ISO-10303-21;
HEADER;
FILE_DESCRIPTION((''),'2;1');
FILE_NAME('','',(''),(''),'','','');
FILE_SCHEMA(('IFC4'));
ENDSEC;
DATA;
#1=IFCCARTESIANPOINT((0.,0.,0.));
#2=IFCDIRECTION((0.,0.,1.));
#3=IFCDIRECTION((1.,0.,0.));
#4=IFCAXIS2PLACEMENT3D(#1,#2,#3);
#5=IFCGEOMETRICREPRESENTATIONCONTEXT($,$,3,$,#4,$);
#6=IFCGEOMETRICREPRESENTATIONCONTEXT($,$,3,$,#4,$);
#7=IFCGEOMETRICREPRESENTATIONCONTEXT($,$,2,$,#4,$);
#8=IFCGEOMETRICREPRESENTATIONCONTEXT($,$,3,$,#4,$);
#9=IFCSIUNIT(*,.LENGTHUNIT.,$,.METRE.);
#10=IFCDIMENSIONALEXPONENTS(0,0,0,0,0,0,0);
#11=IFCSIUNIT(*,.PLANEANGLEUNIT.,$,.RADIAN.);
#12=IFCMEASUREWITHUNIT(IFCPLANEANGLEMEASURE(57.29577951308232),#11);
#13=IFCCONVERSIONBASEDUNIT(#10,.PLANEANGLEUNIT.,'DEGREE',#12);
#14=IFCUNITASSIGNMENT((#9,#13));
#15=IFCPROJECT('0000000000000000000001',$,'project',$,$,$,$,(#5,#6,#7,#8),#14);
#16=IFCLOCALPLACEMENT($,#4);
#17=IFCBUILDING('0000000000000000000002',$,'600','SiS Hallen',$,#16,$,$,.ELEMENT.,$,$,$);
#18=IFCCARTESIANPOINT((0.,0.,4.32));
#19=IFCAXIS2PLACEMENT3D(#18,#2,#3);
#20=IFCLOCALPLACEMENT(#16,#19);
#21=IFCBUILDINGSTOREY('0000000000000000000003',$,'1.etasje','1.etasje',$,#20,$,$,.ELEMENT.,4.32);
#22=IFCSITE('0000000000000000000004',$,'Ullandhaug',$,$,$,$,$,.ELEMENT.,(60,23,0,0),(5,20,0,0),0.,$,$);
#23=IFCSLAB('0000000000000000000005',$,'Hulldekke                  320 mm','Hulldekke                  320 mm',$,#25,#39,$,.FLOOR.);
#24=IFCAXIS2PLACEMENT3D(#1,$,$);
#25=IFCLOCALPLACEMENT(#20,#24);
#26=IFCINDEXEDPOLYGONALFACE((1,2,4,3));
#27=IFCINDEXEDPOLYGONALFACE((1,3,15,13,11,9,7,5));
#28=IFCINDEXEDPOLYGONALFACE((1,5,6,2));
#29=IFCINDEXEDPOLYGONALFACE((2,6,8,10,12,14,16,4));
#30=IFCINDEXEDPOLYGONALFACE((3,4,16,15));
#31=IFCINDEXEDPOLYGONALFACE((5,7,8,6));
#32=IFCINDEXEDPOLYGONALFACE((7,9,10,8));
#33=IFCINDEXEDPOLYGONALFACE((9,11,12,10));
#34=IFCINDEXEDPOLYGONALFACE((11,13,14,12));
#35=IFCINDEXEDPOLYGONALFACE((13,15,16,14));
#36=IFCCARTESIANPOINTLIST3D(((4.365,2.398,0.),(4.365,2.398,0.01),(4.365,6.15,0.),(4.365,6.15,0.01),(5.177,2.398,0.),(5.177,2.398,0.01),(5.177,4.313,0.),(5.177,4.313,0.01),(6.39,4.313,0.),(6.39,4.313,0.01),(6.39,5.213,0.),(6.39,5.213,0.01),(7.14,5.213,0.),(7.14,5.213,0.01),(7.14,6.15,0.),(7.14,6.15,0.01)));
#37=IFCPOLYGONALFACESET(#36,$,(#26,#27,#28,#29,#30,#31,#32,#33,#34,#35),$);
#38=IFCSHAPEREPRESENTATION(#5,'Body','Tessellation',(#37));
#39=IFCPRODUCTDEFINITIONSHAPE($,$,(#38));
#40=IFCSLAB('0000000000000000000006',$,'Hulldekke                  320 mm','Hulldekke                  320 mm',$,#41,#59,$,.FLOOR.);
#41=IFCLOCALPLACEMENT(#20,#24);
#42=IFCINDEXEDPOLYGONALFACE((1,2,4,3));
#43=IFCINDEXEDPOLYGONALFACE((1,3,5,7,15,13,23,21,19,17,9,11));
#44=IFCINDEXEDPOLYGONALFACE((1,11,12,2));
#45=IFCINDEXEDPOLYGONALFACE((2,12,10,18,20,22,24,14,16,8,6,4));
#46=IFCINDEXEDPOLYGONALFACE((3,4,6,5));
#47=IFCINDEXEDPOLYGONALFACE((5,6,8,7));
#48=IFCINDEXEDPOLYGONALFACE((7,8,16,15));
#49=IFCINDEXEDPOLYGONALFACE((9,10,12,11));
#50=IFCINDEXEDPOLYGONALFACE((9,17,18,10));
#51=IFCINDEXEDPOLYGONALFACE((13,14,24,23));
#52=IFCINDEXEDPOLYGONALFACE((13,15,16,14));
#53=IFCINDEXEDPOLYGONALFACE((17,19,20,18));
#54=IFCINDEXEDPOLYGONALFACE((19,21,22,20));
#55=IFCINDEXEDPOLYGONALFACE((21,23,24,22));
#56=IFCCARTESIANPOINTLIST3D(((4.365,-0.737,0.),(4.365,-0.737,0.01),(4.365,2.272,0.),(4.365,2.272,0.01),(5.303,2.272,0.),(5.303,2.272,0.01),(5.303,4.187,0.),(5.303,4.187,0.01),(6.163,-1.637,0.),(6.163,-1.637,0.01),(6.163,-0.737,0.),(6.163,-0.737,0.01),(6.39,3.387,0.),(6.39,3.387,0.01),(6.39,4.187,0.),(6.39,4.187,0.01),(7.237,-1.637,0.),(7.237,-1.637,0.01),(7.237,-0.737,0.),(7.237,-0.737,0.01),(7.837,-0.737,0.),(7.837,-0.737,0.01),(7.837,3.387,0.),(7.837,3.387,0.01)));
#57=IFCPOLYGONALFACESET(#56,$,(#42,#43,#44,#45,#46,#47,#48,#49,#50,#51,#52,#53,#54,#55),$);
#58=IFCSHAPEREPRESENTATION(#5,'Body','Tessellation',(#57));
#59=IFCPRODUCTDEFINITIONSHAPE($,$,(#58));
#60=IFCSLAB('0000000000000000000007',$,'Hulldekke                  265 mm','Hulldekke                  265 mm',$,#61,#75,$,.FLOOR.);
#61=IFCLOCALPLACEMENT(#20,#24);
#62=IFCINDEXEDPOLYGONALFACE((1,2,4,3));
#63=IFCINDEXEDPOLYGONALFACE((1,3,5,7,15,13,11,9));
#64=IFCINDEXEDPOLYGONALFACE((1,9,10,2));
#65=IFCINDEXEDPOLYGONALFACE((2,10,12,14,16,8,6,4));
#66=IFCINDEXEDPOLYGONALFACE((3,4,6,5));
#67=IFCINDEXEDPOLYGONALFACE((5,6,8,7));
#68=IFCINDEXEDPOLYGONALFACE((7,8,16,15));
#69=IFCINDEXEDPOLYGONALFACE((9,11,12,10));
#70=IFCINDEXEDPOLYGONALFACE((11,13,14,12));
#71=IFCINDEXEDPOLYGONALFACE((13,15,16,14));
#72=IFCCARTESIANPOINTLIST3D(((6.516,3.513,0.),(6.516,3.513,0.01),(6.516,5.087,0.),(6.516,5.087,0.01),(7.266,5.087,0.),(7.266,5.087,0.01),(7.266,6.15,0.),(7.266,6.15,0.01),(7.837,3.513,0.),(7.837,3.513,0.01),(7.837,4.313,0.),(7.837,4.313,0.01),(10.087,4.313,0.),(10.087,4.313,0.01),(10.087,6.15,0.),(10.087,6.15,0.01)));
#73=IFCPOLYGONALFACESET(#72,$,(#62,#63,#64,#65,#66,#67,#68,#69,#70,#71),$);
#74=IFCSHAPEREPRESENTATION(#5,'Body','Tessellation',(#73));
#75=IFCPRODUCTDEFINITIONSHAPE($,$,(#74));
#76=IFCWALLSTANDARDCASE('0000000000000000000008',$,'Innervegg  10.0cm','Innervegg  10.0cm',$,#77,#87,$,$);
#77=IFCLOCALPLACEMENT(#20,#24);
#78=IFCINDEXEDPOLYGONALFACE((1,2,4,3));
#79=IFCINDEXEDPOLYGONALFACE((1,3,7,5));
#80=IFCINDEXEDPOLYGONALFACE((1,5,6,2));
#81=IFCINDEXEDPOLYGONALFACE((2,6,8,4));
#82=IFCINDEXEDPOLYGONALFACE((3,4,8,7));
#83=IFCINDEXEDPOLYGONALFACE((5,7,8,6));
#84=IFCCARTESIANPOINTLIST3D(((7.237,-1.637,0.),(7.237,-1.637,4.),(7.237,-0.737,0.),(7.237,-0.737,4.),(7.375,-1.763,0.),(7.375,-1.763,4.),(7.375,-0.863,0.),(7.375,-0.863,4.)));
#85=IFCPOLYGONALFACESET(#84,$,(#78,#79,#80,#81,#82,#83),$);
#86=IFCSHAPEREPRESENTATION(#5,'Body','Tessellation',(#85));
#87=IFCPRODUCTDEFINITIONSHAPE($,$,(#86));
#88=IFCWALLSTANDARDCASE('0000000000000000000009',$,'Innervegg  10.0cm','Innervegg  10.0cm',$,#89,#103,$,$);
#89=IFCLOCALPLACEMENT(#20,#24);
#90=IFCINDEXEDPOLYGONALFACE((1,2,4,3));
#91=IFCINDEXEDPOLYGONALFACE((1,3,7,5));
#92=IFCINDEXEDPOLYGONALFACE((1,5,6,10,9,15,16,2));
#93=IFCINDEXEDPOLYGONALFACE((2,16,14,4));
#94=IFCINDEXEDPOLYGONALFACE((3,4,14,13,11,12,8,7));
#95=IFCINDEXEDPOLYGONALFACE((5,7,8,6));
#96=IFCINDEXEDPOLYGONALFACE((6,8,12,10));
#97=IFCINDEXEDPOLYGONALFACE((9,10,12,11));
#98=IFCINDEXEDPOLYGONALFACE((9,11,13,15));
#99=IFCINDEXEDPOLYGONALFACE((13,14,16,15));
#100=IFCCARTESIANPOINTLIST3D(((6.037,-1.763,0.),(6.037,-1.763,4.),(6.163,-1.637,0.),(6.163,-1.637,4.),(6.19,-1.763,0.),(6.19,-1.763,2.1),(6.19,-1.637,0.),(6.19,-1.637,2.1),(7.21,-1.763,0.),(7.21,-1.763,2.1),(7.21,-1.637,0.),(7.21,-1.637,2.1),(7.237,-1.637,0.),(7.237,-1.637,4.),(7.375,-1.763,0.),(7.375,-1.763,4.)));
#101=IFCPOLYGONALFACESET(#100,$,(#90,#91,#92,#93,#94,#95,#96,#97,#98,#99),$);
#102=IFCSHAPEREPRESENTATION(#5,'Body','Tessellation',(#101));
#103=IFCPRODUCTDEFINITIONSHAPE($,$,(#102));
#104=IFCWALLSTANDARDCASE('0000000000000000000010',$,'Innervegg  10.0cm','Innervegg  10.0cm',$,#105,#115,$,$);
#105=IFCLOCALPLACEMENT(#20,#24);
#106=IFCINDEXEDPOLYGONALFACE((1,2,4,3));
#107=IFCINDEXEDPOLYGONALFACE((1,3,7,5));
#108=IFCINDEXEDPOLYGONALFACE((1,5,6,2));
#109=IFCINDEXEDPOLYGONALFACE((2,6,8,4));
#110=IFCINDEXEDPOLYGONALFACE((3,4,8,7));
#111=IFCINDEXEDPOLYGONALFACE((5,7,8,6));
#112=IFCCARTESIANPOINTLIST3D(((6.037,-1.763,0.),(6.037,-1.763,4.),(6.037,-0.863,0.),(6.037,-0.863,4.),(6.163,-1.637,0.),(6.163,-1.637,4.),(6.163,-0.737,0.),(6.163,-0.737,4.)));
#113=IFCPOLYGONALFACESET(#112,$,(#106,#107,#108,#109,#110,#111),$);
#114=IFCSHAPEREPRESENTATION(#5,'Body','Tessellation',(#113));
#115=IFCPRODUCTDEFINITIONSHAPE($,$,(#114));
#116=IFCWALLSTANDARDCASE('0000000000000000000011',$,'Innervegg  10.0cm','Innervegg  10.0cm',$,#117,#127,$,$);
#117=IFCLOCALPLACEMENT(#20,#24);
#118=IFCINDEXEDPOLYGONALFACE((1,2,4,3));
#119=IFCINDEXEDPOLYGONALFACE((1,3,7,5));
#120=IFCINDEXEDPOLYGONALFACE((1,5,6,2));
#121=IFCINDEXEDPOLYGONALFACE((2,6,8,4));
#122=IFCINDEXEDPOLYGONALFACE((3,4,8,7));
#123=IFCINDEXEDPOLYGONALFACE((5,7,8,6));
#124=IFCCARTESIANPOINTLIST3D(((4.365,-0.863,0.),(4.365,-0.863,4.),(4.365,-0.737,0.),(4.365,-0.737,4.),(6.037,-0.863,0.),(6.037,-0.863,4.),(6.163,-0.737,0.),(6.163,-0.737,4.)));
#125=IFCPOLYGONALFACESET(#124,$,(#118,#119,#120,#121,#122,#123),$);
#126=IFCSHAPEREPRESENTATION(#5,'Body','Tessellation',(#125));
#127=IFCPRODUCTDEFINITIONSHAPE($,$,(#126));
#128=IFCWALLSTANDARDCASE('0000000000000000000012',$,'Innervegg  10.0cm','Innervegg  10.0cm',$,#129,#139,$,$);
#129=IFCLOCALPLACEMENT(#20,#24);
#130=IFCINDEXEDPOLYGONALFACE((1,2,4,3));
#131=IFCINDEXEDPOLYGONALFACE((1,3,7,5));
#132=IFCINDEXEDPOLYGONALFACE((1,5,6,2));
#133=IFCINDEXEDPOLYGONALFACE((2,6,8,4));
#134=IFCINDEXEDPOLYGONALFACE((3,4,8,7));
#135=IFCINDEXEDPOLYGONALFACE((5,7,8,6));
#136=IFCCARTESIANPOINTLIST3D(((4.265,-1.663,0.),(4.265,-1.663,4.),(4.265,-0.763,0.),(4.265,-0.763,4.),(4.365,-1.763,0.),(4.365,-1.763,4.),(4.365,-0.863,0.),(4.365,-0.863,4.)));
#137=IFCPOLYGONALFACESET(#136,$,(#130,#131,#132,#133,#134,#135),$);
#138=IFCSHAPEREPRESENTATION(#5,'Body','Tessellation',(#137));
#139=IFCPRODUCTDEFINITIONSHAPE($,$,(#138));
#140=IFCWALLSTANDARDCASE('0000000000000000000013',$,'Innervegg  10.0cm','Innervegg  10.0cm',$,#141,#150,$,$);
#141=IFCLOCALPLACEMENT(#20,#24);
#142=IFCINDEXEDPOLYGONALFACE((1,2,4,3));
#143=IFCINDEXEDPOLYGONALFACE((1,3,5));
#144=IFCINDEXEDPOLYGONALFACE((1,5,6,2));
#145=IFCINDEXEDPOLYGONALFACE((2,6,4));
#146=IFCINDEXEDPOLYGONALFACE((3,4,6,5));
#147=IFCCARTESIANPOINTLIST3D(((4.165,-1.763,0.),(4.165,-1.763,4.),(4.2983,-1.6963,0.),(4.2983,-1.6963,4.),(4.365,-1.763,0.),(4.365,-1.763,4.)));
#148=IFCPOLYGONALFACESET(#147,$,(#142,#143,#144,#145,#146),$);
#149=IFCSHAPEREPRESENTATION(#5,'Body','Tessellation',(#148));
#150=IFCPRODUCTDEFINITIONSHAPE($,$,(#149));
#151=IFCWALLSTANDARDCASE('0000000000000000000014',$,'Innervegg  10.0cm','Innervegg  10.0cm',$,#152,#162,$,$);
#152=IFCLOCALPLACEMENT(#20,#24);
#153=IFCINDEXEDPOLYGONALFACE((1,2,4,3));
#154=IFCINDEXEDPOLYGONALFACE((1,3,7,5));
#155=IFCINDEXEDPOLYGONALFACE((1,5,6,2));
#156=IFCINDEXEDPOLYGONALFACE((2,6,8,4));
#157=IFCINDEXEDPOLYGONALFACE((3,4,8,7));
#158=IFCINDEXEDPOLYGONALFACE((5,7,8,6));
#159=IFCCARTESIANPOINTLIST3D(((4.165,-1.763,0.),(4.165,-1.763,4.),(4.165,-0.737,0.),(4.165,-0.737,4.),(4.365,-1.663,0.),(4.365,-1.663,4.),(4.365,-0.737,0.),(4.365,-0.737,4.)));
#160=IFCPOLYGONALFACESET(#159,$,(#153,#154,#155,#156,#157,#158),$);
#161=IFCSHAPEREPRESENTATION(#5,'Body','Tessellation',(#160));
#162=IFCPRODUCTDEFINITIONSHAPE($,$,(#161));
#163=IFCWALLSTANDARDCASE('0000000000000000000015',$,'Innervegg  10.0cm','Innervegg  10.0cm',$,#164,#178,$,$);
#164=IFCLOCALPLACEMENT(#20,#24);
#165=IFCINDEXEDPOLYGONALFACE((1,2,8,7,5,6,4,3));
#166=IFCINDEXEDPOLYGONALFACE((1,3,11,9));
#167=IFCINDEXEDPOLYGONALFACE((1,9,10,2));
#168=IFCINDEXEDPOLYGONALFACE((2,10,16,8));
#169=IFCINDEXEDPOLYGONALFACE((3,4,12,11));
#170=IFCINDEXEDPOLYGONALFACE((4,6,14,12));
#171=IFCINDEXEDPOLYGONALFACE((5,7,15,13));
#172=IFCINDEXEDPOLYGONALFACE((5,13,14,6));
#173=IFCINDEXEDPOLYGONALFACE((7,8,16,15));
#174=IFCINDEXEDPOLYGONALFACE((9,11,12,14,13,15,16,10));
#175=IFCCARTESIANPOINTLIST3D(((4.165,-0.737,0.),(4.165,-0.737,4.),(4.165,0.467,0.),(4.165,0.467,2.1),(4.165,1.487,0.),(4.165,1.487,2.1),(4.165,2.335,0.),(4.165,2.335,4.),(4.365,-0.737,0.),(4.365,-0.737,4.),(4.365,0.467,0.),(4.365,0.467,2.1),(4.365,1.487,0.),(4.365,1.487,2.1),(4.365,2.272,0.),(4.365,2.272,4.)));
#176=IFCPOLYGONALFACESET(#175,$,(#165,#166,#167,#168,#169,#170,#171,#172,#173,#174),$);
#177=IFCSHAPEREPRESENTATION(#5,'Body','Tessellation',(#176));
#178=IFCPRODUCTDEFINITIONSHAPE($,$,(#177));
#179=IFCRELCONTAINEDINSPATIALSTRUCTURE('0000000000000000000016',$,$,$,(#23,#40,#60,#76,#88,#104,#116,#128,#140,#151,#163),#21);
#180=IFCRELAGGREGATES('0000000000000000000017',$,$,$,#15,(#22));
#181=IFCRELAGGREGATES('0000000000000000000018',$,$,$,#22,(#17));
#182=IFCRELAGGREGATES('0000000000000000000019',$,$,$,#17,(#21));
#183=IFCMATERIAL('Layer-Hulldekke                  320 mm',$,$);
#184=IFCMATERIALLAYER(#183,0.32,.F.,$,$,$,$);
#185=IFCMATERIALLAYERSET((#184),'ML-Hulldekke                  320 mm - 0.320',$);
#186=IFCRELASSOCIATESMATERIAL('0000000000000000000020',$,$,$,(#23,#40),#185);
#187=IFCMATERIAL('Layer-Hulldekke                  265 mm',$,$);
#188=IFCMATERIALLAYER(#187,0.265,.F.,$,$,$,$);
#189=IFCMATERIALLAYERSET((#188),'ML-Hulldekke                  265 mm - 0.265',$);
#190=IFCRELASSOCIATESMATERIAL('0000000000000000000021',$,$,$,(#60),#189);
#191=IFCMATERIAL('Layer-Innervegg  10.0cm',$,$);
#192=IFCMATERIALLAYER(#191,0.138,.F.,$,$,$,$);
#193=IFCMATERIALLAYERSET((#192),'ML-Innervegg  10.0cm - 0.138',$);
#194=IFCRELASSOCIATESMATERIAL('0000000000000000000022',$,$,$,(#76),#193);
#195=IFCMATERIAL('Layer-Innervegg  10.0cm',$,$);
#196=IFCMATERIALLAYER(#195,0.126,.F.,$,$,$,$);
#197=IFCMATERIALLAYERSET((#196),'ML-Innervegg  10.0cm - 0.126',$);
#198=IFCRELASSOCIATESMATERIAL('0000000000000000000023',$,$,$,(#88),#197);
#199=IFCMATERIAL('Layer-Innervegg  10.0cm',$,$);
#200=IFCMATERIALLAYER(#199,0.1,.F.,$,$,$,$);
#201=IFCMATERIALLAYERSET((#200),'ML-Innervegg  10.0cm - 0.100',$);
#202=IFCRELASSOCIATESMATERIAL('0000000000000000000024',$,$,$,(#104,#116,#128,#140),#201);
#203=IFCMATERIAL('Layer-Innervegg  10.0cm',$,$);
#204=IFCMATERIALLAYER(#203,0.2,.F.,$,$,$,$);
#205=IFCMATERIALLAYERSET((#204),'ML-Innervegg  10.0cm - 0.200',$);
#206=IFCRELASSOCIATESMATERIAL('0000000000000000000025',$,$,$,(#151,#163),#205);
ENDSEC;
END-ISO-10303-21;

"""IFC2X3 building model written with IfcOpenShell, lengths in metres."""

from ifc_helpers import new_model, entity, si_unit, converted_unit, frame, origin_with_axes, place, context, project, spatial, polyline, outline, extrude, material, layer, layer_set, layer_usage, element, save


model = new_model("IFC2X3")

# Units and contexts
context_of_model_1 = context(None, 3, world=origin_with_axes())
context_of_model_2 = context(None, 3, world=origin_with_axes())
context_of_model_3 = context(None, 2, world=origin_with_axes())
context_of_model_4 = context(None, 3, world=origin_with_axes())
ifc_project = project(units=[si_unit("LENGTHUNIT", "METRE"), converted_unit("PLANEANGLEUNIT", "DEGREE", entity("IfcPlaneAngleMeasure", 57.29577951308232), si_unit("PLANEANGLEUNIT", "RADIAN"), dimensions=[0, 0, 0, 0, 0, 0, 0])], contexts=[context_of_model_1, context_of_model_2, context_of_model_3, context_of_model_4])

# Site, building, storey
site = spatial("IfcSite", under=ifc_project, Name="Ullandhaug", CompositionType="ELEMENT", RefLatitude=(60, 23, 0, 0), RefLongitude=(5, 20, 0, 0), RefElevation=0.0)
building_placement = place(None, origin_with_axes())
building = spatial("IfcBuilding", under=site, at=building_placement, Name="600", Description="SiS Hallen", CompositionType="ELEMENT")
storey_placement = place(building_placement, frame((0.0, 0.0, 4.32), z_axis=(0.0, 0.0, 1.0), x_axis=(1.0, 0.0, 0.0)))
storey = spatial("IfcBuildingStorey", under=building, at=storey_placement, Name="1.etasje", Description="1.etasje", CompositionType="ELEMENT", Elevation=4.32)

# Slabs
ifc_material_1 = material(Name="Layer-Hulldekke                  320 mm")
ifc_layer_1 = layer(ifc_material_1, 0.32, ventilated=False)
ifc_layer_set_1 = layer_set([ifc_layer_1], Name="ML-Hulldekke                  320 mm - 0.320")
ifc_layer_usage_1 = layer_usage(ifc_layer_set_1, "AXIS2", "POSITIVE", 0.0)
slab_1_placement = place(storey_placement, frame((4.365, 2.398, 0.0), z_axis=(0.0, 0.0, 1.0), x_axis=(1.0, 0.0, 0.0)))
element("IfcSlab", 1, at=slab_1_placement, inside=storey, material=ifc_layer_usage_1, Name="Hulldekke                  320 mm", Description="Hulldekke                  320 mm", PredefinedType="FLOOR", context=context_of_model_1, shape_type="SweptSolid", body=[
    extrude(outline(polyline([(0.0, 0.0), (0.812, 0.0), (0.812, 1.915), (2.025, 1.915), (2.025, 2.815), (2.775, 2.815), (2.775, 3.752), (0.0, 3.752), (0.0, 0.0)])), origin_with_axes(), (0.0, 0.0, 1.0), 0.01),
])
slab_2_placement = place(storey_placement, frame((6.163, -1.637, 0.0), z_axis=(0.0, 0.0, 1.0), x_axis=(1.0, 0.0, 0.0)))
element("IfcSlab", 2, at=slab_2_placement, inside=storey, material=ifc_layer_usage_1, Name="Hulldekke                  320 mm", Description="Hulldekke                  320 mm", PredefinedType="FLOOR", context=context_of_model_1, shape_type="SweptSolid", body=[
    extrude(outline(polyline([(0.0, 0.0), (1.074, 0.0), (1.074, 0.9), (1.674, 0.9), (1.674, 5.024), (0.227, 5.024), (0.227, 5.824), (-0.86, 5.824), (-0.86, 3.909), (-1.798, 3.909), (-1.798, 0.9), (0.0, 0.9), (0.0, 0.0)])), origin_with_axes(), (0.0, 0.0, 1.0), 0.01),
])
ifc_material_2 = material(Name="Layer-Hulldekke                  265 mm")
ifc_layer_2 = layer(ifc_material_2, 0.265, ventilated=False)
ifc_layer_set_2 = layer_set([ifc_layer_2], Name="ML-Hulldekke                  265 mm - 0.265")
ifc_layer_usage_2 = layer_usage(ifc_layer_set_2, "AXIS2", "POSITIVE", 0.0)
slab_3_placement = place(storey_placement, frame((6.516, 3.513, 0.0), z_axis=(0.0, 0.0, 1.0), x_axis=(1.0, 0.0, 0.0)))
element("IfcSlab", 3, at=slab_3_placement, inside=storey, material=ifc_layer_usage_2, Name="Hulldekke                  265 mm", Description="Hulldekke                  265 mm", PredefinedType="FLOOR", context=context_of_model_1, shape_type="SweptSolid", body=[
    extrude(outline(polyline([(0.0, 0.0), (1.321, 0.0), (1.321, 0.8), (3.571, 0.8), (3.571, 2.637), (0.75, 2.637), (0.75, 1.574), (0.0, 1.574), (0.0, 0.0)])), origin_with_axes(), (0.0, 0.0, 1.0), 0.01),
])

# Wall
ifc_material_3 = material(Name="Layer-Innervegg  10.0cm")
ifc_layer_3 = layer(ifc_material_3, 0.138, ventilated=False)
ifc_layer_set_3 = layer_set([ifc_layer_3], Name="ML-Innervegg  10.0cm - 0.138")
ifc_layer_usage_3 = layer_usage(ifc_layer_set_3, "AXIS2", "POSITIVE", 0.0)
wall_1_placement = place(storey_placement, frame((7.237, -0.737, 0.0), z_axis=(0.0, 0.0, 1.0), x_axis=(0.0, -1.0, 0.0)))
element("IfcWallStandardCase", 4, at=wall_1_placement, inside=storey, material=ifc_layer_usage_3, Name="Innervegg  10.0cm", Description="Innervegg  10.0cm", context=context_of_model_1, shape_type="SweptSolid", body=[
    extrude(outline(polyline([(0.0, 0.0), (0.9, 0.0), (1.026, 0.138), (0.126, 0.138), (0.0, 0.0)])), frame((0.0, 0.0, 0.0), z_axis=(0.0, 0.0, 1.0), x_axis=(1.0, 0.0, 0.0)), (0.0, 0.0, 1.0), 4.0),
])

# Wall, opening
ifc_material_4 = material(Name="Layer-Innervegg  10.0cm")
ifc_layer_4 = layer(ifc_material_4, 0.126, ventilated=False)
ifc_layer_set_4 = layer_set([ifc_layer_4], Name="ML-Innervegg  10.0cm - 0.126")
ifc_layer_usage_4 = layer_usage(ifc_layer_set_4, "AXIS2", "POSITIVE", 0.0)
wall_2_placement = place(storey_placement, frame((7.237, -1.637, 0.0), z_axis=(0.0, 0.0, 1.0), x_axis=(-1.0, 0.0, 0.0)))
wall_2 = element("IfcWallStandardCase", 5, at=wall_2_placement, inside=storey, material=ifc_layer_usage_4, Name="Innervegg  10.0cm", Description="Innervegg  10.0cm", context=context_of_model_1, shape_type="SweptSolid", body=[
    extrude(outline(polyline([(0.0, 0.0), (1.074, 0.0), (1.2, 0.126), (-0.138, 0.126), (0.0, 0.0)])), frame((0.0, 0.0, 0.0), z_axis=(0.0, 0.0, 1.0), x_axis=(1.0, 0.0, 0.0)), (0.0, 0.0, 1.0), 4.0),
])
opening_1_placement = place(wall_2_placement, frame((0.027, 0.126, 0.0), z_axis=(0.0, 0.0, 1.0), x_axis=(1.0, 0.0, 0.0)))
element("IfcOpeningElement", 6, at=opening_1_placement, cuts=wall_2, context=context_of_model_1, shape_type="SweptSolid", body=[
    extrude(outline(polyline([(0.0, 0.0), (2.1, 0.0), (2.1, 1.02), (0.0, 1.02), (0.0, 0.0)])), frame((0.0, 0.0, 0.0), z_axis=(0.0, 1.0, 0.0), x_axis=(0.0, 0.0, 1.0)), (0.0, 0.0, -1.0), 0.126),
])

# Walls
ifc_material_5 = material(Name="Layer-Innervegg  10.0cm")
ifc_layer_5 = layer(ifc_material_5, 0.1, ventilated=False)
ifc_layer_set_5 = layer_set([ifc_layer_5], Name="ML-Innervegg  10.0cm - 0.100")
ifc_layer_usage_5 = layer_usage(ifc_layer_set_5, "AXIS2", "POSITIVE", 0.0)
wall_3_placement = place(storey_placement, frame((6.163, -1.637, 0.0), z_axis=(0.0, 0.0, 1.0), x_axis=(0.0, 1.0, 0.0)))
element("IfcWallStandardCase", 7, at=wall_3_placement, inside=storey, material=ifc_layer_usage_5, Name="Innervegg  10.0cm", Description="Innervegg  10.0cm", context=context_of_model_1, shape_type="SweptSolid", body=[
    extrude(outline(polyline([(0.0, 0.0), (0.9, 0.0), (0.774, 0.126), (-0.126, 0.126), (0.0, 0.0)])), frame((0.0, 0.0, 0.0), z_axis=(0.0, 0.0, 1.0), x_axis=(1.0, 0.0, 0.0)), (0.0, 0.0, 1.0), 4.0),
])
wall_4_placement = place(storey_placement, frame((6.163, -0.737, 0.0), z_axis=(0.0, 0.0, 1.0), x_axis=(-1.0, 0.0, 0.0)))
element("IfcWallStandardCase", 8, at=wall_4_placement, inside=storey, material=ifc_layer_usage_5, Name="Innervegg  10.0cm", Description="Innervegg  10.0cm", context=context_of_model_1, shape_type="SweptSolid", body=[
    extrude(outline(polyline([(0.0, 0.0), (1.798, 0.0), (1.798, 0.126), (0.126, 0.126), (0.0, 0.0)])), frame((0.0, 0.0, 0.0), z_axis=(0.0, 0.0, 1.0), x_axis=(1.0, 0.0, 0.0)), (0.0, 0.0, 1.0), 4.0),
])
wall_5_placement = place(storey_placement, frame((4.265, -0.763, 0.0), z_axis=(0.0, 0.0, 1.0), x_axis=(0.0, -1.0, 0.0)))
element("IfcWallStandardCase", 9, at=wall_5_placement, inside=storey, material=ifc_layer_usage_5, Name="Innervegg  10.0cm", Description="Innervegg  10.0cm", context=context_of_model_1, shape_type="SweptSolid", body=[
    extrude(outline(polyline([(0.0, 0.0), (0.9, 0.0), (1.0, 0.1), (0.1, 0.1), (0.0, 0.0)])), frame((0.0, 0.0, 0.0), z_axis=(0.0, 0.0, 1.0), x_axis=(1.0, 0.0, 0.0)), (0.0, 0.0, 1.0), 4.0),
])
wall_6_placement = place(storey_placement, frame((4.265, -1.663, 0.0), z_axis=(0.0, 0.0, 1.0), x_axis=(1.0, 0.0, 0.0)))
element("IfcWallStandardCase", 10, at=wall_6_placement, inside=storey, material=ifc_layer_usage_5, Name="Innervegg  10.0cm", Description="Innervegg  10.0cm", context=context_of_model_1, shape_type="SweptSolid", body=[
    extrude(outline(polyline([(0.0, 0.0), (0.1, 0.0), (-0.1, 0.1), (0.1, 0.1), (0.0, 0.0)])), frame((0.0, 0.0, 0.0), z_axis=(0.0, 0.0, -1.0), x_axis=(1.0, 0.0, 0.0)), (0.0, 0.0, -1.0), 4.0),
])
ifc_material_6 = material(Name="Layer-Innervegg  10.0cm")
ifc_layer_6 = layer(ifc_material_6, 0.2, ventilated=False)
ifc_layer_set_6 = layer_set([ifc_layer_6], Name="ML-Innervegg  10.0cm - 0.200")
ifc_layer_usage_6 = layer_usage(ifc_layer_set_6, "AXIS2", "POSITIVE", 0.0)
wall_7_placement = place(storey_placement, frame((4.365, -1.663, 0.0), z_axis=(0.0, 0.0, 1.0), x_axis=(0.0, 1.0, 0.0)))
element("IfcWallStandardCase", 11, at=wall_7_placement, inside=storey, material=ifc_layer_usage_6, Name="Innervegg  10.0cm", Description="Innervegg  10.0cm", context=context_of_model_1, shape_type="SweptSolid", body=[
    extrude(outline(polyline([(0.0, 0.0), (0.926, 0.0), (0.926, 0.2), (-0.1, 0.2), (0.0, 0.0)])), frame((0.0, 0.0, 0.0), z_axis=(0.0, 0.0, 1.0), x_axis=(1.0, 0.0, 0.0)), (0.0, 0.0, 1.0), 4.0),
])

# Wall, opening
wall_8_placement = place(storey_placement, frame((4.365, -0.737, 0.0), z_axis=(0.0, 0.0, 1.0), x_axis=(0.0, 1.0, 0.0)))
wall_8 = element("IfcWallStandardCase", 12, at=wall_8_placement, inside=storey, material=ifc_layer_usage_6, Name="Innervegg  10.0cm", Description="Innervegg  10.0cm", context=context_of_model_1, shape_type="SweptSolid", body=[
    extrude(outline(polyline([(0.0, 0.0), (3.009, 0.0), (3.072, 0.2), (0.0, 0.2), (0.0, 0.0)])), frame((0.0, 0.0, 0.0), z_axis=(0.0, 0.0, 1.0), x_axis=(1.0, 0.0, 0.0)), (0.0, 0.0, 1.0), 4.0),
])
opening_2_placement = place(wall_8_placement, frame((1.204, 0.2, 0.0), z_axis=(0.0, 0.0, 1.0), x_axis=(1.0, 0.0, 0.0)))
element("IfcOpeningElement", 13, at=opening_2_placement, cuts=wall_8, context=context_of_model_1, shape_type="SweptSolid", body=[
    extrude(outline(polyline([(0.0, 0.0), (2.1, 0.0), (2.1, 1.02), (0.0, 1.02), (0.0, 0.0)])), frame((0.0, 0.0, 0.0), z_axis=(0.0, 1.0, 0.0), x_axis=(0.0, 0.0, 1.0)), (0.0, 0.0, -1.0), 0.2),
])

save(model, "model.ifc")
